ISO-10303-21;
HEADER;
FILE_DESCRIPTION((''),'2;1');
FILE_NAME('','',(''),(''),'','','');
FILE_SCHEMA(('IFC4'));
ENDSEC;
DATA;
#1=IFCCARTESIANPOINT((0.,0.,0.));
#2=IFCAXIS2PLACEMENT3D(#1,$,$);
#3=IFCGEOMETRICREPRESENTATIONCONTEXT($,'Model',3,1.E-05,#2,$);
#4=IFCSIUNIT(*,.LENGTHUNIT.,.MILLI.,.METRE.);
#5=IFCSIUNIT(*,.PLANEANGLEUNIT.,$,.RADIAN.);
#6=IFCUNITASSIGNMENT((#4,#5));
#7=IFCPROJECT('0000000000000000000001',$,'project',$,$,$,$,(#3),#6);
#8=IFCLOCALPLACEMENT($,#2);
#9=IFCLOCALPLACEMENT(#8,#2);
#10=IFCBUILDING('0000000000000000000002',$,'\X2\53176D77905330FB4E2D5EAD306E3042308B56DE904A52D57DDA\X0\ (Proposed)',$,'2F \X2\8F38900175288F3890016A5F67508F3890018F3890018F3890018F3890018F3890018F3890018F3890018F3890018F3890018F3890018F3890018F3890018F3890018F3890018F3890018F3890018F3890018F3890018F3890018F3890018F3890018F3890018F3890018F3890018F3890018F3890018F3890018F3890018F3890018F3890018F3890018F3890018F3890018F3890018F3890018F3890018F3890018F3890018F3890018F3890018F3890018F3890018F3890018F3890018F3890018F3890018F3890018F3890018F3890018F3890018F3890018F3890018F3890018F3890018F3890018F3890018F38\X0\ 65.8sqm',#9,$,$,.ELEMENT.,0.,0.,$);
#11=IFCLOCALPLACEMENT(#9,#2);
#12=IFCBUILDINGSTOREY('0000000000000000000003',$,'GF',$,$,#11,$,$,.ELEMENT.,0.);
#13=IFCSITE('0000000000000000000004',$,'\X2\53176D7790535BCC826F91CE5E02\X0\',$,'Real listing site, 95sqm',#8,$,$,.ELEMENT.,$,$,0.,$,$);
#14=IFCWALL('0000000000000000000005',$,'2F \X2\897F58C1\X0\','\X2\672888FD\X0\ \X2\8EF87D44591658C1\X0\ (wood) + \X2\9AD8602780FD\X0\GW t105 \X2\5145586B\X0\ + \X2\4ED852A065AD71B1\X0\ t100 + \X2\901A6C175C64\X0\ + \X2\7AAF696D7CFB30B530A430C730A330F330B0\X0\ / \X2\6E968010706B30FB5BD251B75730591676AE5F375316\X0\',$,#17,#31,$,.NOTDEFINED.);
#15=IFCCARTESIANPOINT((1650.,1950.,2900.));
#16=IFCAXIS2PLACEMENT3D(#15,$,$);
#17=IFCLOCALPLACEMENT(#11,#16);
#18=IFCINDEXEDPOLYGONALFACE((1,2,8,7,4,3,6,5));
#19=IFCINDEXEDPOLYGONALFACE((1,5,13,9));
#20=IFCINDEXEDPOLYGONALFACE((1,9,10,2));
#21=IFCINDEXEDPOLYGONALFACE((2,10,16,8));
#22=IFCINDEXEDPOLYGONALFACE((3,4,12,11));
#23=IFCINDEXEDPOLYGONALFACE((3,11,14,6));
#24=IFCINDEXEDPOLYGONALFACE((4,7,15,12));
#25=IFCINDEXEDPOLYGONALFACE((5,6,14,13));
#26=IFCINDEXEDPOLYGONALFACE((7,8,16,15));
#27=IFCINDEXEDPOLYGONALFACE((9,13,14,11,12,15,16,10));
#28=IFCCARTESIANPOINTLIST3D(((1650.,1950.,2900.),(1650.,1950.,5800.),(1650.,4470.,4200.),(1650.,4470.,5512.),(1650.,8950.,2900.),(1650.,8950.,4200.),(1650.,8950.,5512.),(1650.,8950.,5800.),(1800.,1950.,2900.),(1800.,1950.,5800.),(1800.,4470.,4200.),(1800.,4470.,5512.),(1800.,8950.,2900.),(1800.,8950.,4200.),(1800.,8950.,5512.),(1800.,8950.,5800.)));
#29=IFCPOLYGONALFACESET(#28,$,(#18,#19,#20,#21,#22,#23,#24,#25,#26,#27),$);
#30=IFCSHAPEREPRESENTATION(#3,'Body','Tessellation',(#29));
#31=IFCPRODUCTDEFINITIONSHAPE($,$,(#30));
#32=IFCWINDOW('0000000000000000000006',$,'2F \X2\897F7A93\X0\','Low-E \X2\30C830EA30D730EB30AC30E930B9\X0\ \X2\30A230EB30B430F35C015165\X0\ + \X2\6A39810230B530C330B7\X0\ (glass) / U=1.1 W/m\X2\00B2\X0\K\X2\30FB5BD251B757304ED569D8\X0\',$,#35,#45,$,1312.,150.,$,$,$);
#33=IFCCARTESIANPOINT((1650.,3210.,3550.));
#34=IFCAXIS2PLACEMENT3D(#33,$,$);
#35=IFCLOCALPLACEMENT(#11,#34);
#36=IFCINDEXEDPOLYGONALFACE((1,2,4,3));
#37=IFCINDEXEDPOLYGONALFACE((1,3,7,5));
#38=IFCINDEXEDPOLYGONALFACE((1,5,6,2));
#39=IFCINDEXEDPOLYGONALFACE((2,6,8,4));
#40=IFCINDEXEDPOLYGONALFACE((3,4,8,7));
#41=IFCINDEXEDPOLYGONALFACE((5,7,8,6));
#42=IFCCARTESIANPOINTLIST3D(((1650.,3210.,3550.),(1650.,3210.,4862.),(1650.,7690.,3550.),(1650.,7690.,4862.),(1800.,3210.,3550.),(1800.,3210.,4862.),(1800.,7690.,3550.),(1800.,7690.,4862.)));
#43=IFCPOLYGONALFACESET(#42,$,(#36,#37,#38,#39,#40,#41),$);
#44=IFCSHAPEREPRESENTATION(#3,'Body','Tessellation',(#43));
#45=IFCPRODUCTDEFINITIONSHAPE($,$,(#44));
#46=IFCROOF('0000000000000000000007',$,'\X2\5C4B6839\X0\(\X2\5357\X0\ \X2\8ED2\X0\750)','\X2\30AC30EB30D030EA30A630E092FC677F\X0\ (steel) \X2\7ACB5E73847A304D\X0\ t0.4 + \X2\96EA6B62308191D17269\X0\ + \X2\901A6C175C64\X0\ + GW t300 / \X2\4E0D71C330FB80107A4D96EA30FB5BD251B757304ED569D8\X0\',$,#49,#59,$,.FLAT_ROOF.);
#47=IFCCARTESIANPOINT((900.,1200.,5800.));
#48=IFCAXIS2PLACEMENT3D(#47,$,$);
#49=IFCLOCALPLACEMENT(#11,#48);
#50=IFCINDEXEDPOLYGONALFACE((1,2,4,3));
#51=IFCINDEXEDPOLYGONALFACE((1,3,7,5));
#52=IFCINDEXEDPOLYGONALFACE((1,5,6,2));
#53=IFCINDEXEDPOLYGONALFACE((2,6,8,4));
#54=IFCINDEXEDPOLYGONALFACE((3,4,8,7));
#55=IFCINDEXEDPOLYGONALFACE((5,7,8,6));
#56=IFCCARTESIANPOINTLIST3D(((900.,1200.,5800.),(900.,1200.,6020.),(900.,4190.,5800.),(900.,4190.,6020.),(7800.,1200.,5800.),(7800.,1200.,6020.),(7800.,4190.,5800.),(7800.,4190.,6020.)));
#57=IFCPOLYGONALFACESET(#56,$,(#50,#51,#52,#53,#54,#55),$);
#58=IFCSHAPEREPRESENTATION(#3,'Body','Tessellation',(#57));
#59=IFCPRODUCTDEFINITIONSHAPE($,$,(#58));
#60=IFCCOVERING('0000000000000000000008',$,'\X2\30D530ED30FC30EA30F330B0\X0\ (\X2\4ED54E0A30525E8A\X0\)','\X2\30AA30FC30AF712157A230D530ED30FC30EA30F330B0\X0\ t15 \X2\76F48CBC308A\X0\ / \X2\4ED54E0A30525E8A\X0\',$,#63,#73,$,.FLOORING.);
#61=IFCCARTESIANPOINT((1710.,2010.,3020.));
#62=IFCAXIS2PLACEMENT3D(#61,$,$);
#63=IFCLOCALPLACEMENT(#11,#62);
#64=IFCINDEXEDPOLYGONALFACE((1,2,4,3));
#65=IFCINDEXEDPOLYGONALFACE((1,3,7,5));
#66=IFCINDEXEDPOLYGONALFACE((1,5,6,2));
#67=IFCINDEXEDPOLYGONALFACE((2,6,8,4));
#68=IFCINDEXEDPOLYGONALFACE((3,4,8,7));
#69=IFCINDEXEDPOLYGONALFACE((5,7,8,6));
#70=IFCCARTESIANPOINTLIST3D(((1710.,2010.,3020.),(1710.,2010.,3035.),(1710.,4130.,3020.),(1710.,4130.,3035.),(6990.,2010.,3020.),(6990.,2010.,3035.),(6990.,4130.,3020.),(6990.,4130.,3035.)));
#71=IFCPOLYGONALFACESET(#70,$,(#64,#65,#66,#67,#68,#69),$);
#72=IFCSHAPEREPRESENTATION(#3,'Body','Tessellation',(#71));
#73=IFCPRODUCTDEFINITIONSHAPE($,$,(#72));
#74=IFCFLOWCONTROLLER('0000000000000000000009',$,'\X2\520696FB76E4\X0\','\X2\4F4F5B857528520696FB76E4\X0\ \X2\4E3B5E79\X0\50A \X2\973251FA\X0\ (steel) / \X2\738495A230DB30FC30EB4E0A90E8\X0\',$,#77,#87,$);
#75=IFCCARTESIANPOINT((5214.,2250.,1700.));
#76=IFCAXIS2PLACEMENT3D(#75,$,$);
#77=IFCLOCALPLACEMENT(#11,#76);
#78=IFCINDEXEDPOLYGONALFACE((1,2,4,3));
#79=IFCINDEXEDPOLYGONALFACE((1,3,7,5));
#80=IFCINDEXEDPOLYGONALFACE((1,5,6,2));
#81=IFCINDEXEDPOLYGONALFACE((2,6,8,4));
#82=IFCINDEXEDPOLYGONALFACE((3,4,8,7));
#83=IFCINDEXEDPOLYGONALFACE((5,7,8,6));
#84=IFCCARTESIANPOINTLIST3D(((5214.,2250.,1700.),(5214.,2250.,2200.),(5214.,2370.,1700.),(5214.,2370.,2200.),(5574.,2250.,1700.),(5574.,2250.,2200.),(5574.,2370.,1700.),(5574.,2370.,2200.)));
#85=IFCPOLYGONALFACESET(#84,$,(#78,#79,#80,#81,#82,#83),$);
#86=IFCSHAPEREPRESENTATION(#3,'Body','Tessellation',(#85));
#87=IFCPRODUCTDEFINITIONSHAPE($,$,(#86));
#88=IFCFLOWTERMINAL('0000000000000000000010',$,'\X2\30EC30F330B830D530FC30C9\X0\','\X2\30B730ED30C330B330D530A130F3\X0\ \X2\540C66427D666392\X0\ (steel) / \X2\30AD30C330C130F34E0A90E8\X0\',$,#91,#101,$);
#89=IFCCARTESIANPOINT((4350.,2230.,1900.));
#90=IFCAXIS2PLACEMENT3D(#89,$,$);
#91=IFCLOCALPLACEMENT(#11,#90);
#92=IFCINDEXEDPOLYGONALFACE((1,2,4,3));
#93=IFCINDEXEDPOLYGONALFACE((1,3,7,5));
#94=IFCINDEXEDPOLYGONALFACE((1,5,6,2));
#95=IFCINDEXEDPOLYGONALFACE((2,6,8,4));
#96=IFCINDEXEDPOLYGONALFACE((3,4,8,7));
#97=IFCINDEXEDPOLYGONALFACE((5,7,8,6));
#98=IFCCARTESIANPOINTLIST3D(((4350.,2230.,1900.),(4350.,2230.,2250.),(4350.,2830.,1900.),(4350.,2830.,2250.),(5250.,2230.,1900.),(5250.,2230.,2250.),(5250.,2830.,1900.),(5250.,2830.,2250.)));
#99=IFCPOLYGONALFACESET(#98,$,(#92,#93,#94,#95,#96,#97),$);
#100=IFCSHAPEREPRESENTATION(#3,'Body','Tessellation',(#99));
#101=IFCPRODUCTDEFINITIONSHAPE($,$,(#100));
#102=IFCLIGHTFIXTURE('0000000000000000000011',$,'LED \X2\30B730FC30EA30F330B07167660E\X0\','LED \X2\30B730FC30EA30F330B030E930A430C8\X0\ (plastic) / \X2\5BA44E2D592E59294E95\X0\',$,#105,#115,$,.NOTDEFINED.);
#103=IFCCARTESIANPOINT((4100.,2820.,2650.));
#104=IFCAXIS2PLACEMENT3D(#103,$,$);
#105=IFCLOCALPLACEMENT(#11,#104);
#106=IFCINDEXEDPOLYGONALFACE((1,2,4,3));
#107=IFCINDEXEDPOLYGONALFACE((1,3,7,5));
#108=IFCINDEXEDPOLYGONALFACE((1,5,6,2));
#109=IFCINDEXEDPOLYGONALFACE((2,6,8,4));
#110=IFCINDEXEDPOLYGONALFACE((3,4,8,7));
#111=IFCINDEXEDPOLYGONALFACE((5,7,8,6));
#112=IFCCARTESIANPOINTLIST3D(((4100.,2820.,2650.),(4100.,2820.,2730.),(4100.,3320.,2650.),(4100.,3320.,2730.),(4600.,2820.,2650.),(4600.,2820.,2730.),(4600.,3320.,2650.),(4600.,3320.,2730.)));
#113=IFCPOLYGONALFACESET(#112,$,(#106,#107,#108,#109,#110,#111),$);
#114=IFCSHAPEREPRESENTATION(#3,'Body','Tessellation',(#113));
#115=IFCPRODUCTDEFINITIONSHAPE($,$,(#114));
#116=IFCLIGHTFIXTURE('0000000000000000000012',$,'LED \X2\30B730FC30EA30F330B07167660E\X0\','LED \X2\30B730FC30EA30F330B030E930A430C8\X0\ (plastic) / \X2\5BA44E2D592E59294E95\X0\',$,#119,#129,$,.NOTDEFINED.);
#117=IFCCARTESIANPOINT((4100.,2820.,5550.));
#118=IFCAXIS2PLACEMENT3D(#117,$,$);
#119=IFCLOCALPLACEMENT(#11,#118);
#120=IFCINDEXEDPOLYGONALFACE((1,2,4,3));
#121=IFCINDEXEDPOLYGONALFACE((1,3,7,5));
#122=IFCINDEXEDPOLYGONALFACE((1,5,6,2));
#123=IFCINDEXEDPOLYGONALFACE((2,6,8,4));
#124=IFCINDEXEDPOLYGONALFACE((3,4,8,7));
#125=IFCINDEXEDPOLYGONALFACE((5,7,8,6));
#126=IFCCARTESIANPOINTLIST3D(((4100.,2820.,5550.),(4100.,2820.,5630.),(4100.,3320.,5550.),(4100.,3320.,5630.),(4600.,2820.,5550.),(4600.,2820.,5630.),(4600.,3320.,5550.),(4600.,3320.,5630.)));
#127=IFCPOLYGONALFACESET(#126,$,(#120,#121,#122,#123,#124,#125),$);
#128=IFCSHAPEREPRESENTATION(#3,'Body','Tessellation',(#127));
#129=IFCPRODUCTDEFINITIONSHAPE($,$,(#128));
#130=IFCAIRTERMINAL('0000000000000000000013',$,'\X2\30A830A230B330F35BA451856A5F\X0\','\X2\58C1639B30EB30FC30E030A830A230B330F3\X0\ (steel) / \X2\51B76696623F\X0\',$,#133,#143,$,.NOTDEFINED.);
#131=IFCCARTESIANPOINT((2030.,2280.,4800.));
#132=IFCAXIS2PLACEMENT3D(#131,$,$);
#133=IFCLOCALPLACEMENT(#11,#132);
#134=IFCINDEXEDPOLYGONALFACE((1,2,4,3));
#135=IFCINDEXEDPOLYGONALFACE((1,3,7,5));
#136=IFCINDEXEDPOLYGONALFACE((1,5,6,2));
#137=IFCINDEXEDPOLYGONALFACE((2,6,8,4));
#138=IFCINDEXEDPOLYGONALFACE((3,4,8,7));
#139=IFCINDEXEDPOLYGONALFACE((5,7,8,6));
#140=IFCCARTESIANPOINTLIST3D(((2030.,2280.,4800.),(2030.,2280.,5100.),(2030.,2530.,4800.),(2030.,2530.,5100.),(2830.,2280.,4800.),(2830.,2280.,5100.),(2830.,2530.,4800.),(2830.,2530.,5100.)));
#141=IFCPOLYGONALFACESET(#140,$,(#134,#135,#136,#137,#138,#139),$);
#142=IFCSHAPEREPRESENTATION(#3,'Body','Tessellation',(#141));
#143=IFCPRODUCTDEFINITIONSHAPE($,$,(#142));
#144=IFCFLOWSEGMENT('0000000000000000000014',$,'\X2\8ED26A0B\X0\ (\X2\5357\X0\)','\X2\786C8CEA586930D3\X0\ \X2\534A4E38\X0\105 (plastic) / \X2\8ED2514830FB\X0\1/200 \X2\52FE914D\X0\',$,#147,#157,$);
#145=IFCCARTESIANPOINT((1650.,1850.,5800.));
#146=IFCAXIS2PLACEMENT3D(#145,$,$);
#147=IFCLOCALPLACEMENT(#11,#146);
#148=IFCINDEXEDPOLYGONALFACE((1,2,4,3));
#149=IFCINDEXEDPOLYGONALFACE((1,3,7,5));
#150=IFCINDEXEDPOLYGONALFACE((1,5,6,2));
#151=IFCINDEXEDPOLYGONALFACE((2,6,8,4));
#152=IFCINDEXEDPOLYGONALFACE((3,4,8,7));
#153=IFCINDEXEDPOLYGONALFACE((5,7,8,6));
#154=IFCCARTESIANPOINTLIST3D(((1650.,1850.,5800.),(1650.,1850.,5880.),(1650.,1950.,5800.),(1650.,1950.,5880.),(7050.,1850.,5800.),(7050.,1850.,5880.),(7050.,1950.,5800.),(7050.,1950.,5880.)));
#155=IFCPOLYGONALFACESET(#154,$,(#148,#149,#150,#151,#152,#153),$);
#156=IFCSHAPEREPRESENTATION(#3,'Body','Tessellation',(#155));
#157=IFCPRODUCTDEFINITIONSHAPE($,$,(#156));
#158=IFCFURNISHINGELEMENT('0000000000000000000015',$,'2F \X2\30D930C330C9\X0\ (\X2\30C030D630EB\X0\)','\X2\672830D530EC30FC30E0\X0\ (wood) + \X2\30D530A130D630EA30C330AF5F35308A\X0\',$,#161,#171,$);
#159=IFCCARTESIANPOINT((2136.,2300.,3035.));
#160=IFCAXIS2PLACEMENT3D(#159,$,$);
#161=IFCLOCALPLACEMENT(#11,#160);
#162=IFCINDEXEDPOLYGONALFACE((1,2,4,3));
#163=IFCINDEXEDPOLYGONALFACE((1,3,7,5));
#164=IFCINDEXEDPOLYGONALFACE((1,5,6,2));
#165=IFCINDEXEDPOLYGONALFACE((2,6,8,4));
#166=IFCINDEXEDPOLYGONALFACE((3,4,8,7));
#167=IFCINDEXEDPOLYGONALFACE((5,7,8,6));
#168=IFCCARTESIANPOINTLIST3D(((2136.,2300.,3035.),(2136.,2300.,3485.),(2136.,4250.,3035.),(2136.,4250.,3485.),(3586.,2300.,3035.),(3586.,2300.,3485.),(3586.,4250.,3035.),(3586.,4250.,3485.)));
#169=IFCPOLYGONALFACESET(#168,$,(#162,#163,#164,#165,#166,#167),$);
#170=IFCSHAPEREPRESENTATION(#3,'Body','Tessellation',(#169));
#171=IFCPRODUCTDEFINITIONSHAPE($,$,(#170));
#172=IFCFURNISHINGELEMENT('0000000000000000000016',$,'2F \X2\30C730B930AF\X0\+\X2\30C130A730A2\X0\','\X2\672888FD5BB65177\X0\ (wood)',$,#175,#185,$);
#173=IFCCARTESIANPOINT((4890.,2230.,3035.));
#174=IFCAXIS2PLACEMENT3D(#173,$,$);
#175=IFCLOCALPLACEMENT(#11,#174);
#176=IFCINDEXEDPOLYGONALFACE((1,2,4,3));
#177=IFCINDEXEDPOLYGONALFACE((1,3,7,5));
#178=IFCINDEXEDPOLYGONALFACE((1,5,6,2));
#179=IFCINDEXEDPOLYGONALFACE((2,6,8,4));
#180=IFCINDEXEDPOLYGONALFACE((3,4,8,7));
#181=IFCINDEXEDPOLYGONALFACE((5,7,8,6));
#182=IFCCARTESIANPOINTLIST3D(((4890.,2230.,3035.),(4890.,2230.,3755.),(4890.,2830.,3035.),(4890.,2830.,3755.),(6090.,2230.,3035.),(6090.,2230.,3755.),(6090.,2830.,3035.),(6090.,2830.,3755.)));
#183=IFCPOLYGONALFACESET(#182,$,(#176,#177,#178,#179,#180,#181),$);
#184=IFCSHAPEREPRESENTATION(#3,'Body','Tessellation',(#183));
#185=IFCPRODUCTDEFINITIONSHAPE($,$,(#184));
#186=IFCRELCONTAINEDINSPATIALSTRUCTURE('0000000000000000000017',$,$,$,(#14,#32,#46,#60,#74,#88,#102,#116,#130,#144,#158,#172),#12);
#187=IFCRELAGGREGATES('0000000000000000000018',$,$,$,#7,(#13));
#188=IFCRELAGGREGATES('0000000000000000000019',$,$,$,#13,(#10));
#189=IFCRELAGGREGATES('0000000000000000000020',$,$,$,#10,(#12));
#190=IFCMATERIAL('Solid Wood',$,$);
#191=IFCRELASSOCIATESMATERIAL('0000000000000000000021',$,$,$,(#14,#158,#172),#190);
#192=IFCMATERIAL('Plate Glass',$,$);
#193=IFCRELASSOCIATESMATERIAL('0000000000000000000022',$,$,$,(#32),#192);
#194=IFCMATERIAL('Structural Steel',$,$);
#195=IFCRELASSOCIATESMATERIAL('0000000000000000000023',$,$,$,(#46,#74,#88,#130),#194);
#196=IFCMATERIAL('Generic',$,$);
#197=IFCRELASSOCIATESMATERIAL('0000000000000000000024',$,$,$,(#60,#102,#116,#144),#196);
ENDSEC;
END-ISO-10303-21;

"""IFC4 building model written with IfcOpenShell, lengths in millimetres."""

from ifc_helpers import new_model, si_unit, frame, frame_2d, origin, place, context, project, spatial, rectangle, extrude, material, element, fill, save


model = new_model("IFC4")

# Units and contexts
model_context = context("Model", 3, precision=1e-05, world=origin())
ifc_project = project(units=[si_unit("LENGTHUNIT", "METRE", prefix="MILLI"), si_unit("PLANEANGLEUNIT", "RADIAN")], contexts=[model_context])

# Site, building, storey
site_placement = place(None, origin())
site = spatial("IfcSite", under=ifc_project, at=site_placement, Name="北海道富良野市", ObjectType="Real listing site, 95sqm", CompositionType="ELEMENT", RefElevation=0.0)
building_placement = place(site_placement, origin())
building = spatial("IfcBuilding", under=site, at=building_placement, Name="北海道・中庭のある回遊動線 (Proposed)", ObjectType="2F 輸送用輸送機材輸送輸送輸送輸送輸送輸送輸送輸送輸送輸送輸送輸送輸送輸送輸送輸送輸送輸送輸送輸送輸送輸送輸送輸送輸送輸送輸送輸送輸送輸送輸送輸送輸送輸送輸送輸送輸送輸送輸送輸送輸送輸送輸送輸送輸送輸送輸送輸送輸送輸送輸送輸送輸送輸送輸送輸送輸 65.8sqm", CompositionType="ELEMENT", ElevationOfRefHeight=0.0, ElevationOfTerrain=0.0)
storey_placement = place(building_placement, origin())
storey = spatial("IfcBuildingStorey", under=building, at=storey_placement, Name="GF", CompositionType="ELEMENT", Elevation=0.0)

# Shared definitions
ifc_material_1 = material(Name="Solid Wood")

# Wall, opening, window
ifc_material_2 = material(Name="Plate Glass")
wall_1_placement = place(storey_placement, frame((1650.0, 1950.0, 2900.0)))
wall_1 = element("IfcWall", 1, at=wall_1_placement, inside=storey, material=ifc_material_1, Name="2F 西壁", Description="木製 軸組外壁 (wood) + 高性能GW t105 充填 + 付加断熱 t100 + 通気層 + 窯業系サイディング / 準耐火・寒冷地外皮強化", PredefinedType="NOTDEFINED", context=model_context, shape_type="SweptSolid", body=[
    extrude(rectangle(XDim=150.0, YDim=7000.0, at=frame_2d((75.0, 3500.0))), frame((1650.0, 1950.0, 2900.0)), (0.0, 0.0, 1.0), 2900.0),
])
opening_1_placement = place(storey_placement, frame((1650.0, 3210.0, 3550.0)))
opening_1 = element("IfcOpeningElement", 2, at=opening_1_placement, cuts=wall_1, PredefinedType="NOTDEFINED", context=model_context, shape_type="SweptSolid", body=[
    extrude(rectangle(XDim=150.0, YDim=4480.0, at=frame_2d((75.0, 2240.0))), frame((1650.0, 3210.0, 3550.0)), (0.0, 0.0, 1.0), 1312.0),
])
window_1_placement = place(storey_placement, frame((1650.0, 3210.0, 3550.0)))
window_1 = element("IfcWindow", 3, at=window_1_placement, inside=storey, material=ifc_material_2, Name="2F 西窓", Description="Low-E トリプルガラス アルゴン封入 + 樹脂サッシ (glass) / U=1.1 W/m²K・寒冷地仕様", OverallHeight=1312.0, OverallWidth=150.0, context=model_context, shape_type="SweptSolid", body=[
    extrude(rectangle(XDim=150.0, YDim=4480.0, at=frame_2d((75.0, 2240.0))), frame((1650.0, 3210.0, 3550.0)), (0.0, 0.0, 1.0), 1312.0),
])
fill(opening_1, window_1)

# Roof
ifc_material_3 = material(Name="Structural Steel")
for number, where, name in (
    (4, (900.0, 1200.0, 5800.0), "屋根(南 軒750)"),
):
    element("IfcRoof", number, at=place(storey_placement, frame(where)), inside=storey, material=ifc_material_3, Name=name, Description="ガルバリウム鋼板 (steel) 立平葺き t0.4 + 雪止め金物 + 通気層 + GW t300 / 不燃・耐積雪・寒冷地仕様", PredefinedType="FLAT_ROOF", context=model_context, shape_type="SweptSolid", body=[
        extrude(rectangle(XDim=6900.0, YDim=2990.0, at=frame_2d((3450.0, 1495.0))), frame((900.0, 1200.0, 5800.0)), (0.0, 0.0, 1.0), 220.0),
    ])

# Covering
ifc_material_4 = material(Name="Generic")
covering_placement = place(storey_placement, frame((1710.0, 2010.0, 3020.0)))
element("IfcCovering", 5, at=covering_placement, inside=storey, material=ifc_material_4, Name="フローリング (仕上げ床)", Description="オーク無垢フローリング t15 直貼り / 仕上げ床", PredefinedType="FLOORING", context=model_context, shape_type="SweptSolid", body=[
    extrude(rectangle(XDim=5280.0, YDim=2120.0, at=frame_2d((2640.0, 1060.0))), frame((1710.0, 2010.0, 3020.0)), (0.0, 0.0, 1.0), 15.0),
])

# Flow controller
flow_controller_placement = place(storey_placement, frame((5214.0, 2250.0, 1700.0)))
element("IfcFlowController", 6, at=flow_controller_placement, inside=storey, material=ifc_material_3, Name="分電盤", Description="住宅用分電盤 主幹50A 露出 (steel) / 玄関ホール上部", context=model_context, shape_type="SweptSolid", body=[
    extrude(rectangle(XDim=360.0, YDim=120.0, at=frame_2d((180.0, 60.0))), frame((5214.0, 2250.0, 1700.0)), (0.0, 0.0, 1.0), 500.0),
])

# Flow terminal
flow_terminal_placement = place(storey_placement, frame((4350.0, 2230.0, 1900.0)))
element("IfcFlowTerminal", 7, at=flow_terminal_placement, inside=storey, material=ifc_material_3, Name="レンジフード", Description="シロッコファン 同時給排 (steel) / キッチン上部", context=model_context, shape_type="SweptSolid", body=[
    extrude(rectangle(XDim=900.0, YDim=600.0, at=frame_2d((450.0, 300.0))), frame((4350.0, 2230.0, 1900.0)), (0.0, 0.0, 1.0), 350.0),
])

# Light fixtures
light_fixture_1_placement = place(storey_placement, frame((4100.0, 2820.0, 2650.0)))
element("IfcLightFixture", 8, at=light_fixture_1_placement, inside=storey, material=ifc_material_4, Name="LED シーリング照明", Description="LED シーリングライト (plastic) / 室中央天井", PredefinedType="NOTDEFINED", context=model_context, shape_type="SweptSolid", body=[
    extrude(rectangle(XDim=500.0, YDim=500.0, at=frame_2d((250.0, 250.0))), frame((4100.0, 2820.0, 2650.0)), (0.0, 0.0, 1.0), 80.0),
])
light_fixture_2_placement = place(storey_placement, frame((4100.0, 2820.0, 5550.0)))
element("IfcLightFixture", 9, at=light_fixture_2_placement, inside=storey, material=ifc_material_4, Name="LED シーリング照明", Description="LED シーリングライト (plastic) / 室中央天井", PredefinedType="NOTDEFINED", context=model_context, shape_type="SweptSolid", body=[
    extrude(rectangle(XDim=500.0, YDim=500.0, at=frame_2d((250.0, 250.0))), frame((4100.0, 2820.0, 5550.0)), (0.0, 0.0, 1.0), 80.0),
])

# Air terminal
air_terminal_placement = place(storey_placement, frame((2030.0, 2280.0, 4800.0)))
element("IfcAirTerminal", 10, at=air_terminal_placement, inside=storey, material=ifc_material_3, Name="エアコン室内機", Description="壁掛ルームエアコン (steel) / 冷暖房", PredefinedType="NOTDEFINED", context=model_context, shape_type="SweptSolid", body=[
    extrude(rectangle(XDim=800.0, YDim=250.0, at=frame_2d((400.0, 125.0))), frame((2030.0, 2280.0, 4800.0)), (0.0, 0.0, 1.0), 300.0),
])

# Flow segment
flow_segment_placement = place(storey_placement, frame((1650.0, 1850.0, 5800.0)))
element("IfcFlowSegment", 11, at=flow_segment_placement, inside=storey, material=ifc_material_4, Name="軒樋 (南)", Description="硬質塩ビ 半丸105 (plastic) / 軒先・1/200 勾配", context=model_context, shape_type="SweptSolid", body=[
    extrude(rectangle(XDim=5400.0, YDim=100.0, at=frame_2d((2700.0, 50.0))), frame((1650.0, 1850.0, 5800.0)), (0.0, 0.0, 1.0), 80.0),
])

# Furnishing elements
furnishing_1_placement = place(storey_placement, frame((2136.0, 2300.0, 3035.0)))
element("IfcFurnishingElement", 12, at=furnishing_1_placement, inside=storey, material=ifc_material_1, Name="2F ベッド (ダブル)", Description="木フレーム (wood) + ファブリック張り", context=model_context, shape_type="SweptSolid", body=[
    extrude(rectangle(XDim=1450.0, YDim=1950.0, at=frame_2d((725.0, 975.0))), frame((2136.0, 2300.0, 3035.0)), (0.0, 0.0, 1.0), 450.0),
])
furnishing_2_placement = place(storey_placement, frame((4890.0, 2230.0, 3035.0)))
element("IfcFurnishingElement", 13, at=furnishing_2_placement, inside=storey, material=ifc_material_1, Name="2F デスク+チェア", Description="木製家具 (wood)", context=model_context, shape_type="SweptSolid", body=[
    extrude(rectangle(XDim=1200.0, YDim=600.0, at=frame_2d((600.0, 300.0))), frame((4890.0, 2230.0, 3035.0)), (0.0, 0.0, 1.0), 720.0),
])

save(model, "model.ifc")
